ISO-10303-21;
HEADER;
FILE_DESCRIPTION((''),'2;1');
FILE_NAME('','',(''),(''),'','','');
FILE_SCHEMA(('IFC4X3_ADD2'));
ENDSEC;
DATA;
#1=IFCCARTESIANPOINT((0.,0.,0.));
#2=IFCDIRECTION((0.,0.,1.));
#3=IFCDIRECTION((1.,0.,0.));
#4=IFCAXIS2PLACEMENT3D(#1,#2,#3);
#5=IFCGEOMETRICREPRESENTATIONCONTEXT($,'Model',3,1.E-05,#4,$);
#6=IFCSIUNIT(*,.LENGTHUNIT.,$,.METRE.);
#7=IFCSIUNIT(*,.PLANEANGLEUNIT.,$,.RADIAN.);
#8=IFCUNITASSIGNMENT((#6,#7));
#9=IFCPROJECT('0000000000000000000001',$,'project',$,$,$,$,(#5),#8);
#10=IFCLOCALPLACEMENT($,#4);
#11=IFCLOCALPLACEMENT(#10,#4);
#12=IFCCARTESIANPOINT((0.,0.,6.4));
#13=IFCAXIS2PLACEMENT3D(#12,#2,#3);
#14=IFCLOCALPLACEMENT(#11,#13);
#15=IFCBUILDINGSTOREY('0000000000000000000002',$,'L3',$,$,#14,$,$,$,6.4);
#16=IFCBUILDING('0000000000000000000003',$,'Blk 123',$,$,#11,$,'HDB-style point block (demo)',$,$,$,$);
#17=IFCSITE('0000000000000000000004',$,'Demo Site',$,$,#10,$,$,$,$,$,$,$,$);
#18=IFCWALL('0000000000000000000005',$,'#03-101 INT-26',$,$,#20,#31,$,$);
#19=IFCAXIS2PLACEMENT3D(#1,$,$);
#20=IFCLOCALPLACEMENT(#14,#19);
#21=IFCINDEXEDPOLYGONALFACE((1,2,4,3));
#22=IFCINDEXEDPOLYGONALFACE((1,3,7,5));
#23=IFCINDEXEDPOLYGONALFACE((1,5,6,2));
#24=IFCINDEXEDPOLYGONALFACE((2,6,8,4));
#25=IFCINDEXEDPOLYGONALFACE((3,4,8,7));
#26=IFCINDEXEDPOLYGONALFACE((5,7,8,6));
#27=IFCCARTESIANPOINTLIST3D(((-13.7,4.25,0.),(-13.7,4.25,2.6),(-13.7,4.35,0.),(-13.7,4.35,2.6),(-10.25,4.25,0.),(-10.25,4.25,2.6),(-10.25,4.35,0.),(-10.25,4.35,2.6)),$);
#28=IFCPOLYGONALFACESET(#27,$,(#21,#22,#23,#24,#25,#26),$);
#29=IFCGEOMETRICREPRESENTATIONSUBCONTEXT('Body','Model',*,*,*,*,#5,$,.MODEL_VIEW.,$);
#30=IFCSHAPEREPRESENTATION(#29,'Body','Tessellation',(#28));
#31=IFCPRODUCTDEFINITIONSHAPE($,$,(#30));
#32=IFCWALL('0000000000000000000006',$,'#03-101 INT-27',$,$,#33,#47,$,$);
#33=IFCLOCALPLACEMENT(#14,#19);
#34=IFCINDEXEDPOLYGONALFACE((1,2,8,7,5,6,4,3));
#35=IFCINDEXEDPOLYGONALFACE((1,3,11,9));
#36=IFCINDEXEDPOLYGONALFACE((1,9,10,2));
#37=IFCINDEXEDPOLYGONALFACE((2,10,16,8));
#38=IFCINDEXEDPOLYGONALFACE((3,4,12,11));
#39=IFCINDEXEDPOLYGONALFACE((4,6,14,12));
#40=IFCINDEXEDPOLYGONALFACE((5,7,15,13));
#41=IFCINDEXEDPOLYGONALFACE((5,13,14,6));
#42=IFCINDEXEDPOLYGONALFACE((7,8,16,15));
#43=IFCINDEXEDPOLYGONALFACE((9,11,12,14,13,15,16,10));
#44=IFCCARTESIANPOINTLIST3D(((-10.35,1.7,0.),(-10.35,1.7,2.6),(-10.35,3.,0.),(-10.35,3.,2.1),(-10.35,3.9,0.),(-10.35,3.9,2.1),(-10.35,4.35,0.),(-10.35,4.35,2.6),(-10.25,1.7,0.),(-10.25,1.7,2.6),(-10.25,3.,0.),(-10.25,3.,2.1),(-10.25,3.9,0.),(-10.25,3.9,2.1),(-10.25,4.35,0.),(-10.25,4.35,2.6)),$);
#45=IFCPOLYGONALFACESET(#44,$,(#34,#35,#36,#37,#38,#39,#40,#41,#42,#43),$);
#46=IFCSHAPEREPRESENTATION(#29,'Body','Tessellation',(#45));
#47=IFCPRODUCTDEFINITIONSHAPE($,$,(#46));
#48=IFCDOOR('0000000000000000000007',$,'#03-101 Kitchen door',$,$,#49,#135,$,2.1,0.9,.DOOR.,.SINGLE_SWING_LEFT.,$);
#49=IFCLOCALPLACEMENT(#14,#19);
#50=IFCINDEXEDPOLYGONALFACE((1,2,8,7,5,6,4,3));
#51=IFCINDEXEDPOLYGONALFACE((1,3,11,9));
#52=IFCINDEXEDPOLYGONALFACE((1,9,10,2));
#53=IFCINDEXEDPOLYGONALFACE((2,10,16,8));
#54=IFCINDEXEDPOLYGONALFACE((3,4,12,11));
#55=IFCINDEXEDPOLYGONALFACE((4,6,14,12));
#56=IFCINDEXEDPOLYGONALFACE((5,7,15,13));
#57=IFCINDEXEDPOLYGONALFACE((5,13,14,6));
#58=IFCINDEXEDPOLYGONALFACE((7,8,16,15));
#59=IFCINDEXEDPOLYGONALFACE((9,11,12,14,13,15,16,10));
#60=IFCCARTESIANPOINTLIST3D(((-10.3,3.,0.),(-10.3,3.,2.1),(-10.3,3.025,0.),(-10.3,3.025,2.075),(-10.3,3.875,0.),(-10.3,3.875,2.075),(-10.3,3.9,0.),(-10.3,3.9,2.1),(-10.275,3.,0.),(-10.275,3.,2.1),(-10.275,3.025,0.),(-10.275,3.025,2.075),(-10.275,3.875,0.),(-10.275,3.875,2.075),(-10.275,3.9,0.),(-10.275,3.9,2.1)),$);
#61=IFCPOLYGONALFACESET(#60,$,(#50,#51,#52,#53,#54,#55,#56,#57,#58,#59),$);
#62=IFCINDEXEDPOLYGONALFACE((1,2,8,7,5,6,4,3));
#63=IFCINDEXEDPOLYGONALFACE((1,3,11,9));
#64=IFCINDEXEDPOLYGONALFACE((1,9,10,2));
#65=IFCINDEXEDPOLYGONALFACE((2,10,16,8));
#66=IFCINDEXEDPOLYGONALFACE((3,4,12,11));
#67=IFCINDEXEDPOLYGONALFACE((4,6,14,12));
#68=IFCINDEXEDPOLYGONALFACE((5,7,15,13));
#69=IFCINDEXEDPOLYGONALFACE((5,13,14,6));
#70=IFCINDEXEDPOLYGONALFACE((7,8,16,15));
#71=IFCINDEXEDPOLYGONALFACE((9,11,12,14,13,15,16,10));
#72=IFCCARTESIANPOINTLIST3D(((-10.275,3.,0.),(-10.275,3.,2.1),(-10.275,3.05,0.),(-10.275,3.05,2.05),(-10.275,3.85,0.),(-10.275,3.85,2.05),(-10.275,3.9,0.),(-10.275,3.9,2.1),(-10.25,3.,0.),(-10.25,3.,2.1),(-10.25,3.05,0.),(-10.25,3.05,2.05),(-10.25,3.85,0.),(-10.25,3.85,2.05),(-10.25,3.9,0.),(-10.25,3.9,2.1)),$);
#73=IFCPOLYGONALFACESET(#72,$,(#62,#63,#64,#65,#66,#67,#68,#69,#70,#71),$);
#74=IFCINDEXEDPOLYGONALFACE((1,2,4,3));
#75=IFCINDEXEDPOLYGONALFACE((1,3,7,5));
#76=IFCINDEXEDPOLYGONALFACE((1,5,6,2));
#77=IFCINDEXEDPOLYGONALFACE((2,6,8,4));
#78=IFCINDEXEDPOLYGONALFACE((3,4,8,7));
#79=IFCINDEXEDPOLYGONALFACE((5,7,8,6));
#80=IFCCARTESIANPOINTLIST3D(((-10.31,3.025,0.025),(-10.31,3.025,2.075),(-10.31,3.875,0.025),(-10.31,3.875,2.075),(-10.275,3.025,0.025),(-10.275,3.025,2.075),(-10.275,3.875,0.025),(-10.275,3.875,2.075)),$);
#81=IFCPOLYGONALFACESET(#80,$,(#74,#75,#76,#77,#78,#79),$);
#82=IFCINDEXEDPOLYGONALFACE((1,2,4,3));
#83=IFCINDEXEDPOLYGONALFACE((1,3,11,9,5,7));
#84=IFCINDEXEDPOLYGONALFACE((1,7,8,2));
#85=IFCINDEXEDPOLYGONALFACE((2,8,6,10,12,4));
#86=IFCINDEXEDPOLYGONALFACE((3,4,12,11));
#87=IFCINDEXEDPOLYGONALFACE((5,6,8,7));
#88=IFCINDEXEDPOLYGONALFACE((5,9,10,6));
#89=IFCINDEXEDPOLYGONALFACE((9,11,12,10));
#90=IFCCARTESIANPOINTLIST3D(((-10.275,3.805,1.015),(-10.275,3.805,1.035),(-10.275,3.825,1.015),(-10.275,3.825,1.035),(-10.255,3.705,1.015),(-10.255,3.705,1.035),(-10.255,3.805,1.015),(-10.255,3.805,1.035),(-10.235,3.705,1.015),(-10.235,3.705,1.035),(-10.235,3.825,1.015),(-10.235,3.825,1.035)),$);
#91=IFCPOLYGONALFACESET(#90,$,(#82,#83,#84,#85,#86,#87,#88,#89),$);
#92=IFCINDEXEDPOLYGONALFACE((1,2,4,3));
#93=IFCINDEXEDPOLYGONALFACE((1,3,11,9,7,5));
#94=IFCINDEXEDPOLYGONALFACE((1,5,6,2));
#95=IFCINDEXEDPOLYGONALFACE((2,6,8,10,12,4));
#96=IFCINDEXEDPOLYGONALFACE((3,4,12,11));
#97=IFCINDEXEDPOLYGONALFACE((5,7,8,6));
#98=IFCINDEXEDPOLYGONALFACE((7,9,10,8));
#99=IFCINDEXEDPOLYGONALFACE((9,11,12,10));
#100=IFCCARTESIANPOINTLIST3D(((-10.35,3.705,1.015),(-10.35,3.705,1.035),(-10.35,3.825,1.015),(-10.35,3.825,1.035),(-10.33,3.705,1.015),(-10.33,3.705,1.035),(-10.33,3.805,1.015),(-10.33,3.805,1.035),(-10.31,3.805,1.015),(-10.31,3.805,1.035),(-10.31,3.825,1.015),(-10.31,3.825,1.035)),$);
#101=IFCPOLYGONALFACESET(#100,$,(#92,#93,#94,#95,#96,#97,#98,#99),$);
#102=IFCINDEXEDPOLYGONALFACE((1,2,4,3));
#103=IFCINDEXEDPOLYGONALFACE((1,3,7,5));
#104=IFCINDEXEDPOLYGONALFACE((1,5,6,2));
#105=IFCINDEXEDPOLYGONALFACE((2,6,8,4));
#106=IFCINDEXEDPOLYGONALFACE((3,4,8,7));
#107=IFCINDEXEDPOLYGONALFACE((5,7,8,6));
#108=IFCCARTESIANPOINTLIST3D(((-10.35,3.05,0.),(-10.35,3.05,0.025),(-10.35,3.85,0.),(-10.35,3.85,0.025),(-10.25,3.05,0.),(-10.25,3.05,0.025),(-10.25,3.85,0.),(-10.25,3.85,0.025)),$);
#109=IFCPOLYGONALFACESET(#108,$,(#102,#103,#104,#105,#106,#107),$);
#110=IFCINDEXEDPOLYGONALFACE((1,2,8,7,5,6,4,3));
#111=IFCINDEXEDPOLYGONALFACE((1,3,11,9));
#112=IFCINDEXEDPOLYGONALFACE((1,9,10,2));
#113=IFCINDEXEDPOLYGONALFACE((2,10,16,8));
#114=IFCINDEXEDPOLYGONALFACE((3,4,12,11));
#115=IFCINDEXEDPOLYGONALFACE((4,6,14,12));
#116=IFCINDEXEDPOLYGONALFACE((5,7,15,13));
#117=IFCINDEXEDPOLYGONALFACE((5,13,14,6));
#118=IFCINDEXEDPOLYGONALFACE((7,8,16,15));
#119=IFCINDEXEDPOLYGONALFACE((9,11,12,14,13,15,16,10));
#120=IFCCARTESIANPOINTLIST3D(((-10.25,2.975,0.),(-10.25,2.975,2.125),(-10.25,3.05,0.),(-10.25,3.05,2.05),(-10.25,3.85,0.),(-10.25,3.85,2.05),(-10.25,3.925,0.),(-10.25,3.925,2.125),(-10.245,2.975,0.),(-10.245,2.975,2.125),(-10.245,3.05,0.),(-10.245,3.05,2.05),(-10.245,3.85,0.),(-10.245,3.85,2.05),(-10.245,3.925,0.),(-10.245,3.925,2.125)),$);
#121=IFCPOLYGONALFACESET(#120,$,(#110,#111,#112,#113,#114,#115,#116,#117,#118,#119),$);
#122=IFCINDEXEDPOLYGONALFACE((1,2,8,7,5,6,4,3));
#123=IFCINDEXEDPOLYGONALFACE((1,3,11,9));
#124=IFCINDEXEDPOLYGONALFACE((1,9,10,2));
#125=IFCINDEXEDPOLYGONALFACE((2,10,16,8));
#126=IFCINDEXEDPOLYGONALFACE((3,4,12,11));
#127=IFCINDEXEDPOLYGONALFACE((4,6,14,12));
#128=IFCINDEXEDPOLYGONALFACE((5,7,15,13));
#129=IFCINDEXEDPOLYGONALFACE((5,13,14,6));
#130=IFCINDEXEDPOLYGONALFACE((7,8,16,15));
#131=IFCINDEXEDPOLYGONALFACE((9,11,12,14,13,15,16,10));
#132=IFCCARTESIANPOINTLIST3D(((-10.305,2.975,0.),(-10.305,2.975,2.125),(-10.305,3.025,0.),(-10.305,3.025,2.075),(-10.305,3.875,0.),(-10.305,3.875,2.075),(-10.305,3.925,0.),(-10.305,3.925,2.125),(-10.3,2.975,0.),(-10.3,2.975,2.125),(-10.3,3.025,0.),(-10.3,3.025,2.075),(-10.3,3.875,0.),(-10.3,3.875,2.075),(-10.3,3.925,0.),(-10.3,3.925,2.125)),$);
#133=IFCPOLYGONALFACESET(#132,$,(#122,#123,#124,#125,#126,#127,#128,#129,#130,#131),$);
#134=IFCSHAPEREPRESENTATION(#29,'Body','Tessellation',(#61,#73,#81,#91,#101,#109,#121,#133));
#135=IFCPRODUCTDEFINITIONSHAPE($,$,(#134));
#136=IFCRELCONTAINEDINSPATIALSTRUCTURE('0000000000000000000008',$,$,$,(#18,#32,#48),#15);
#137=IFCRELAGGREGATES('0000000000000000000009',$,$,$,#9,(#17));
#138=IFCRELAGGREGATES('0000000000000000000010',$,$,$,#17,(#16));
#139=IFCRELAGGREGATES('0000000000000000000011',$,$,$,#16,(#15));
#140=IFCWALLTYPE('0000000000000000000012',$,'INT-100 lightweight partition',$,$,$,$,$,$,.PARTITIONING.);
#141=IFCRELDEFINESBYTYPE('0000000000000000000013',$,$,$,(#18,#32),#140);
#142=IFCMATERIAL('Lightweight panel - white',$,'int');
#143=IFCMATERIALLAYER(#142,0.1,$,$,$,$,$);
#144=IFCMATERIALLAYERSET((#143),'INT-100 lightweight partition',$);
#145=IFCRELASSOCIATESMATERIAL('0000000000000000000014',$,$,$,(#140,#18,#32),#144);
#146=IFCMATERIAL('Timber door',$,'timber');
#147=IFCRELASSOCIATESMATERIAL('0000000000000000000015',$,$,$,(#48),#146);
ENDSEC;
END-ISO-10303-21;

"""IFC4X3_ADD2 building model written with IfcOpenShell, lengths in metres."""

from ifc_helpers import new_model, si_unit, frame, origin_with_axes, place, context, subcontext, project, spatial, line, indexed_curve, outline, extrude, material, layer, layer_set, layer_usage, type_object, element, fill, save


model = new_model("IFC4X3_ADD2")

# Units and contexts
model_context = context("Model", 3, precision=1e-05, world=origin_with_axes())
body_context = subcontext(model_context, "Body", "Model", "MODEL_VIEW")
ifc_project = project(units=[si_unit("LENGTHUNIT", "METRE"), si_unit("PLANEANGLEUNIT", "RADIAN")], contexts=[model_context])

# Site, building, storey
site_placement = place(None, origin_with_axes())
site = spatial("IfcSite", under=ifc_project, at=site_placement, Name="Demo Site")
building_placement = place(site_placement, origin_with_axes())
building = spatial("IfcBuilding", under=site, at=building_placement, Name="Blk 123", LongName="HDB-style point block (demo)")
storey_placement = place(building_placement, frame((0.0, 0.0, 6.4), z_axis=(0.0, 0.0, 1.0), x_axis=(1.0, 0.0, 0.0)))
storey = spatial("IfcBuildingStorey", under=building, at=storey_placement, Name="L3", Elevation=6.4)

# Shared definitions
ifc_material_1 = material(Name="Timber door", Category="timber")

# Wall
ifc_material_2 = material(Name="Lightweight panel - white", Category="int")
ifc_layer_1 = layer(ifc_material_2, 0.1)
ifc_layer_set_1 = layer_set([ifc_layer_1], Name="INT-100 lightweight partition")
ifc_layer_usage_1 = layer_usage(ifc_layer_set_1, "AXIS2", "POSITIVE", -0.05)
wall_type_1 = type_object("IfcWallType", Name="INT-100 lightweight partition", PredefinedType="PARTITIONING", material=ifc_layer_set_1)
wall_1_placement = place(storey_placement, frame((-10.25, 4.3, 0.0), z_axis=(0.0, 0.0, 1.0), x_axis=(-1.0, 0.0, 0.0)))
element("IfcWall", 1, at=wall_1_placement, inside=storey, type_object=wall_type_1, material=ifc_layer_usage_1, Name="#03-101 INT-26", context=body_context, shape_type="SweptSolid", body=[
    extrude(outline(indexed_curve([(0.0, 0.0), (0.0, 0.1), (3.45, 0.1), (3.45, 0.0), (0.0, 0.0)], self_intersect=False)), frame((0.0, -0.05, 0.0), z_axis=(0.0, 0.0, 1.0), x_axis=(1.0, 0.0, 0.0)), (0.0, 0.0, 1.0), 2.6),
])

# Wall, opening, door
wall_2_placement = place(storey_placement, frame((-10.3, 1.7, 0.0), z_axis=(0.0, 0.0, 1.0), x_axis=(0.0, 1.0, 0.0)))
wall_2 = element("IfcWall", 2, at=wall_2_placement, inside=storey, type_object=wall_type_1, material=ifc_layer_usage_1, Name="#03-101 INT-27", context=body_context, shape_type="SweptSolid", body=[
    extrude(outline(indexed_curve([(0.0, 0.0), (0.0, 0.1), (2.65, 0.1), (2.65, 0.0), (0.0, 0.0)], self_intersect=False)), frame((0.0, -0.05, 0.0), z_axis=(0.0, 0.0, 1.0), x_axis=(1.0, 0.0, 0.0)), (0.0, 0.0, 1.0), 2.6),
])
opening_1_placement = place(wall_2_placement, frame((1.3, -0.15, 0.0), z_axis=(0.0, 0.0, 1.0), x_axis=(1.0, 0.0, 0.0)))
opening_1 = element("IfcOpeningElement", 3, at=opening_1_placement, cuts=wall_2, context=body_context, shape_type="SweptSolid", body=[
    extrude(outline(indexed_curve([(0.0, 0.0), (0.0, 0.3), (0.9, 0.3), (0.9, 0.0), (0.0, 0.0)], self_intersect=False)), origin_with_axes(), (0.0, 0.0, 1.0), 2.1),
])
door_1_placement = place(opening_1_placement, frame((0.0, 0.1, 0.0), z_axis=(0.0, 0.0, 1.0), x_axis=(1.0, 0.0, 0.0)))
door_1 = element("IfcDoor", 4, at=door_1_placement, inside=storey, material=ifc_material_1, Name="#03-101 Kitchen door", OperationType="SINGLE_SWING_LEFT", OverallHeight=2.1, OverallWidth=0.9, PredefinedType="DOOR", context=body_context, shape_type="SweptSolid", body=[
    extrude(outline(indexed_curve([(0.0, 0.0), (0.0, 2.1), (0.9, 2.1), (0.9, 0.0), (0.875, 0.0), (0.875, 2.075), (0.025, 2.075), (0.025, 0.0)], segments=[line(1, 2, 3, 4, 5, 6, 7, 8, 1)])), frame((0.0, 0.025, 0.0), z_axis=(0.0, -1.0, 0.0), x_axis=(1.0, 0.0, 0.0)), (0.0, 0.0, -1.0), 0.025),
    extrude(outline(indexed_curve([(0.0, 0.0), (0.0, 2.1), (0.9, 2.1), (0.9, 0.0), (0.85, 0.0), (0.85, 2.05), (0.05, 2.05), (0.05, 0.0)], segments=[line(1, 2, 3, 4, 5, 6, 7, 8, 1)])), frame((0.0, 0.0, 0.0), z_axis=(0.0, -1.0, 0.0), x_axis=(1.0, 0.0, 0.0)), (0.0, 0.0, -1.0), 0.025),
    extrude(outline(indexed_curve([(0.0, 0.0), (0.85, 0.0), (0.85, 0.035), (0.0, 0.035)], segments=[line(1, 2, 3, 4, 1)])), frame((0.025, 0.025, 0.025), z_axis=(0.0, 0.0, 1.0), x_axis=(1.0, 0.0, 0.0)), (0.0, 0.0, 1.0), 2.05),
    extrude(outline(indexed_curve([(0.0, 0.0), (0.0, -0.04), (-0.12, -0.04), (-0.12, -0.02), (-0.02, -0.02), (-0.02, 0.0)], segments=[line(1, 2, 3, 4, 5, 6, 1)])), frame((0.825, 0.025, 1.015), z_axis=(0.0, 0.0, 1.0), x_axis=(1.0, 0.0, 0.0)), (0.0, 0.0, 1.0), 0.02),
    extrude(outline(indexed_curve([(0.0, 0.0), (0.0, 0.04), (-0.12, 0.04), (-0.12, 0.02), (-0.02, 0.02), (-0.02, 0.0)], segments=[line(1, 2, 3, 4, 5, 6, 1)])), frame((0.825, 0.06, 1.015), z_axis=(0.0, 0.0, 1.0), x_axis=(1.0, 0.0, 0.0)), (0.0, 0.0, 1.0), 0.02),
    extrude(outline(indexed_curve([(0.0, 0.0), (0.8, 0.0), (0.8, 0.1), (0.0, 0.1)], segments=[line(1, 2, 3, 4, 1)])), frame((0.05, 0.0, 0.0), z_axis=(0.0, 0.0, 1.0), x_axis=(1.0, 0.0, 0.0)), (0.0, 0.0, 1.0), 0.025),
    extrude(outline(indexed_curve([(0.0, 0.0), (0.0, 2.125), (0.95, 2.125), (0.95, 0.0), (0.875, 0.0), (0.875, 2.05), (0.075, 2.05), (0.075, 0.0)], segments=[line(1, 2, 3, 4, 5, 6, 7, 8, 1)])), frame((-0.025, -0.005, 0.0), z_axis=(0.0, -1.0, 0.0), x_axis=(1.0, 0.0, 0.0)), (0.0, 0.0, -1.0), 0.005),
    extrude(outline(indexed_curve([(0.0, 0.0), (0.0, 2.125), (0.95, 2.125), (0.95, 0.0), (0.9, 0.0), (0.9, 2.075), (0.05, 2.075), (0.05, 0.0)], segments=[line(1, 2, 3, 4, 5, 6, 7, 8, 1)])), frame((-0.025, 0.05, 0.0), z_axis=(0.0, -1.0, 0.0), x_axis=(1.0, 0.0, 0.0)), (0.0, 0.0, -1.0), 0.005),
])
fill(opening_1, door_1)

save(model, "model.ifc")
